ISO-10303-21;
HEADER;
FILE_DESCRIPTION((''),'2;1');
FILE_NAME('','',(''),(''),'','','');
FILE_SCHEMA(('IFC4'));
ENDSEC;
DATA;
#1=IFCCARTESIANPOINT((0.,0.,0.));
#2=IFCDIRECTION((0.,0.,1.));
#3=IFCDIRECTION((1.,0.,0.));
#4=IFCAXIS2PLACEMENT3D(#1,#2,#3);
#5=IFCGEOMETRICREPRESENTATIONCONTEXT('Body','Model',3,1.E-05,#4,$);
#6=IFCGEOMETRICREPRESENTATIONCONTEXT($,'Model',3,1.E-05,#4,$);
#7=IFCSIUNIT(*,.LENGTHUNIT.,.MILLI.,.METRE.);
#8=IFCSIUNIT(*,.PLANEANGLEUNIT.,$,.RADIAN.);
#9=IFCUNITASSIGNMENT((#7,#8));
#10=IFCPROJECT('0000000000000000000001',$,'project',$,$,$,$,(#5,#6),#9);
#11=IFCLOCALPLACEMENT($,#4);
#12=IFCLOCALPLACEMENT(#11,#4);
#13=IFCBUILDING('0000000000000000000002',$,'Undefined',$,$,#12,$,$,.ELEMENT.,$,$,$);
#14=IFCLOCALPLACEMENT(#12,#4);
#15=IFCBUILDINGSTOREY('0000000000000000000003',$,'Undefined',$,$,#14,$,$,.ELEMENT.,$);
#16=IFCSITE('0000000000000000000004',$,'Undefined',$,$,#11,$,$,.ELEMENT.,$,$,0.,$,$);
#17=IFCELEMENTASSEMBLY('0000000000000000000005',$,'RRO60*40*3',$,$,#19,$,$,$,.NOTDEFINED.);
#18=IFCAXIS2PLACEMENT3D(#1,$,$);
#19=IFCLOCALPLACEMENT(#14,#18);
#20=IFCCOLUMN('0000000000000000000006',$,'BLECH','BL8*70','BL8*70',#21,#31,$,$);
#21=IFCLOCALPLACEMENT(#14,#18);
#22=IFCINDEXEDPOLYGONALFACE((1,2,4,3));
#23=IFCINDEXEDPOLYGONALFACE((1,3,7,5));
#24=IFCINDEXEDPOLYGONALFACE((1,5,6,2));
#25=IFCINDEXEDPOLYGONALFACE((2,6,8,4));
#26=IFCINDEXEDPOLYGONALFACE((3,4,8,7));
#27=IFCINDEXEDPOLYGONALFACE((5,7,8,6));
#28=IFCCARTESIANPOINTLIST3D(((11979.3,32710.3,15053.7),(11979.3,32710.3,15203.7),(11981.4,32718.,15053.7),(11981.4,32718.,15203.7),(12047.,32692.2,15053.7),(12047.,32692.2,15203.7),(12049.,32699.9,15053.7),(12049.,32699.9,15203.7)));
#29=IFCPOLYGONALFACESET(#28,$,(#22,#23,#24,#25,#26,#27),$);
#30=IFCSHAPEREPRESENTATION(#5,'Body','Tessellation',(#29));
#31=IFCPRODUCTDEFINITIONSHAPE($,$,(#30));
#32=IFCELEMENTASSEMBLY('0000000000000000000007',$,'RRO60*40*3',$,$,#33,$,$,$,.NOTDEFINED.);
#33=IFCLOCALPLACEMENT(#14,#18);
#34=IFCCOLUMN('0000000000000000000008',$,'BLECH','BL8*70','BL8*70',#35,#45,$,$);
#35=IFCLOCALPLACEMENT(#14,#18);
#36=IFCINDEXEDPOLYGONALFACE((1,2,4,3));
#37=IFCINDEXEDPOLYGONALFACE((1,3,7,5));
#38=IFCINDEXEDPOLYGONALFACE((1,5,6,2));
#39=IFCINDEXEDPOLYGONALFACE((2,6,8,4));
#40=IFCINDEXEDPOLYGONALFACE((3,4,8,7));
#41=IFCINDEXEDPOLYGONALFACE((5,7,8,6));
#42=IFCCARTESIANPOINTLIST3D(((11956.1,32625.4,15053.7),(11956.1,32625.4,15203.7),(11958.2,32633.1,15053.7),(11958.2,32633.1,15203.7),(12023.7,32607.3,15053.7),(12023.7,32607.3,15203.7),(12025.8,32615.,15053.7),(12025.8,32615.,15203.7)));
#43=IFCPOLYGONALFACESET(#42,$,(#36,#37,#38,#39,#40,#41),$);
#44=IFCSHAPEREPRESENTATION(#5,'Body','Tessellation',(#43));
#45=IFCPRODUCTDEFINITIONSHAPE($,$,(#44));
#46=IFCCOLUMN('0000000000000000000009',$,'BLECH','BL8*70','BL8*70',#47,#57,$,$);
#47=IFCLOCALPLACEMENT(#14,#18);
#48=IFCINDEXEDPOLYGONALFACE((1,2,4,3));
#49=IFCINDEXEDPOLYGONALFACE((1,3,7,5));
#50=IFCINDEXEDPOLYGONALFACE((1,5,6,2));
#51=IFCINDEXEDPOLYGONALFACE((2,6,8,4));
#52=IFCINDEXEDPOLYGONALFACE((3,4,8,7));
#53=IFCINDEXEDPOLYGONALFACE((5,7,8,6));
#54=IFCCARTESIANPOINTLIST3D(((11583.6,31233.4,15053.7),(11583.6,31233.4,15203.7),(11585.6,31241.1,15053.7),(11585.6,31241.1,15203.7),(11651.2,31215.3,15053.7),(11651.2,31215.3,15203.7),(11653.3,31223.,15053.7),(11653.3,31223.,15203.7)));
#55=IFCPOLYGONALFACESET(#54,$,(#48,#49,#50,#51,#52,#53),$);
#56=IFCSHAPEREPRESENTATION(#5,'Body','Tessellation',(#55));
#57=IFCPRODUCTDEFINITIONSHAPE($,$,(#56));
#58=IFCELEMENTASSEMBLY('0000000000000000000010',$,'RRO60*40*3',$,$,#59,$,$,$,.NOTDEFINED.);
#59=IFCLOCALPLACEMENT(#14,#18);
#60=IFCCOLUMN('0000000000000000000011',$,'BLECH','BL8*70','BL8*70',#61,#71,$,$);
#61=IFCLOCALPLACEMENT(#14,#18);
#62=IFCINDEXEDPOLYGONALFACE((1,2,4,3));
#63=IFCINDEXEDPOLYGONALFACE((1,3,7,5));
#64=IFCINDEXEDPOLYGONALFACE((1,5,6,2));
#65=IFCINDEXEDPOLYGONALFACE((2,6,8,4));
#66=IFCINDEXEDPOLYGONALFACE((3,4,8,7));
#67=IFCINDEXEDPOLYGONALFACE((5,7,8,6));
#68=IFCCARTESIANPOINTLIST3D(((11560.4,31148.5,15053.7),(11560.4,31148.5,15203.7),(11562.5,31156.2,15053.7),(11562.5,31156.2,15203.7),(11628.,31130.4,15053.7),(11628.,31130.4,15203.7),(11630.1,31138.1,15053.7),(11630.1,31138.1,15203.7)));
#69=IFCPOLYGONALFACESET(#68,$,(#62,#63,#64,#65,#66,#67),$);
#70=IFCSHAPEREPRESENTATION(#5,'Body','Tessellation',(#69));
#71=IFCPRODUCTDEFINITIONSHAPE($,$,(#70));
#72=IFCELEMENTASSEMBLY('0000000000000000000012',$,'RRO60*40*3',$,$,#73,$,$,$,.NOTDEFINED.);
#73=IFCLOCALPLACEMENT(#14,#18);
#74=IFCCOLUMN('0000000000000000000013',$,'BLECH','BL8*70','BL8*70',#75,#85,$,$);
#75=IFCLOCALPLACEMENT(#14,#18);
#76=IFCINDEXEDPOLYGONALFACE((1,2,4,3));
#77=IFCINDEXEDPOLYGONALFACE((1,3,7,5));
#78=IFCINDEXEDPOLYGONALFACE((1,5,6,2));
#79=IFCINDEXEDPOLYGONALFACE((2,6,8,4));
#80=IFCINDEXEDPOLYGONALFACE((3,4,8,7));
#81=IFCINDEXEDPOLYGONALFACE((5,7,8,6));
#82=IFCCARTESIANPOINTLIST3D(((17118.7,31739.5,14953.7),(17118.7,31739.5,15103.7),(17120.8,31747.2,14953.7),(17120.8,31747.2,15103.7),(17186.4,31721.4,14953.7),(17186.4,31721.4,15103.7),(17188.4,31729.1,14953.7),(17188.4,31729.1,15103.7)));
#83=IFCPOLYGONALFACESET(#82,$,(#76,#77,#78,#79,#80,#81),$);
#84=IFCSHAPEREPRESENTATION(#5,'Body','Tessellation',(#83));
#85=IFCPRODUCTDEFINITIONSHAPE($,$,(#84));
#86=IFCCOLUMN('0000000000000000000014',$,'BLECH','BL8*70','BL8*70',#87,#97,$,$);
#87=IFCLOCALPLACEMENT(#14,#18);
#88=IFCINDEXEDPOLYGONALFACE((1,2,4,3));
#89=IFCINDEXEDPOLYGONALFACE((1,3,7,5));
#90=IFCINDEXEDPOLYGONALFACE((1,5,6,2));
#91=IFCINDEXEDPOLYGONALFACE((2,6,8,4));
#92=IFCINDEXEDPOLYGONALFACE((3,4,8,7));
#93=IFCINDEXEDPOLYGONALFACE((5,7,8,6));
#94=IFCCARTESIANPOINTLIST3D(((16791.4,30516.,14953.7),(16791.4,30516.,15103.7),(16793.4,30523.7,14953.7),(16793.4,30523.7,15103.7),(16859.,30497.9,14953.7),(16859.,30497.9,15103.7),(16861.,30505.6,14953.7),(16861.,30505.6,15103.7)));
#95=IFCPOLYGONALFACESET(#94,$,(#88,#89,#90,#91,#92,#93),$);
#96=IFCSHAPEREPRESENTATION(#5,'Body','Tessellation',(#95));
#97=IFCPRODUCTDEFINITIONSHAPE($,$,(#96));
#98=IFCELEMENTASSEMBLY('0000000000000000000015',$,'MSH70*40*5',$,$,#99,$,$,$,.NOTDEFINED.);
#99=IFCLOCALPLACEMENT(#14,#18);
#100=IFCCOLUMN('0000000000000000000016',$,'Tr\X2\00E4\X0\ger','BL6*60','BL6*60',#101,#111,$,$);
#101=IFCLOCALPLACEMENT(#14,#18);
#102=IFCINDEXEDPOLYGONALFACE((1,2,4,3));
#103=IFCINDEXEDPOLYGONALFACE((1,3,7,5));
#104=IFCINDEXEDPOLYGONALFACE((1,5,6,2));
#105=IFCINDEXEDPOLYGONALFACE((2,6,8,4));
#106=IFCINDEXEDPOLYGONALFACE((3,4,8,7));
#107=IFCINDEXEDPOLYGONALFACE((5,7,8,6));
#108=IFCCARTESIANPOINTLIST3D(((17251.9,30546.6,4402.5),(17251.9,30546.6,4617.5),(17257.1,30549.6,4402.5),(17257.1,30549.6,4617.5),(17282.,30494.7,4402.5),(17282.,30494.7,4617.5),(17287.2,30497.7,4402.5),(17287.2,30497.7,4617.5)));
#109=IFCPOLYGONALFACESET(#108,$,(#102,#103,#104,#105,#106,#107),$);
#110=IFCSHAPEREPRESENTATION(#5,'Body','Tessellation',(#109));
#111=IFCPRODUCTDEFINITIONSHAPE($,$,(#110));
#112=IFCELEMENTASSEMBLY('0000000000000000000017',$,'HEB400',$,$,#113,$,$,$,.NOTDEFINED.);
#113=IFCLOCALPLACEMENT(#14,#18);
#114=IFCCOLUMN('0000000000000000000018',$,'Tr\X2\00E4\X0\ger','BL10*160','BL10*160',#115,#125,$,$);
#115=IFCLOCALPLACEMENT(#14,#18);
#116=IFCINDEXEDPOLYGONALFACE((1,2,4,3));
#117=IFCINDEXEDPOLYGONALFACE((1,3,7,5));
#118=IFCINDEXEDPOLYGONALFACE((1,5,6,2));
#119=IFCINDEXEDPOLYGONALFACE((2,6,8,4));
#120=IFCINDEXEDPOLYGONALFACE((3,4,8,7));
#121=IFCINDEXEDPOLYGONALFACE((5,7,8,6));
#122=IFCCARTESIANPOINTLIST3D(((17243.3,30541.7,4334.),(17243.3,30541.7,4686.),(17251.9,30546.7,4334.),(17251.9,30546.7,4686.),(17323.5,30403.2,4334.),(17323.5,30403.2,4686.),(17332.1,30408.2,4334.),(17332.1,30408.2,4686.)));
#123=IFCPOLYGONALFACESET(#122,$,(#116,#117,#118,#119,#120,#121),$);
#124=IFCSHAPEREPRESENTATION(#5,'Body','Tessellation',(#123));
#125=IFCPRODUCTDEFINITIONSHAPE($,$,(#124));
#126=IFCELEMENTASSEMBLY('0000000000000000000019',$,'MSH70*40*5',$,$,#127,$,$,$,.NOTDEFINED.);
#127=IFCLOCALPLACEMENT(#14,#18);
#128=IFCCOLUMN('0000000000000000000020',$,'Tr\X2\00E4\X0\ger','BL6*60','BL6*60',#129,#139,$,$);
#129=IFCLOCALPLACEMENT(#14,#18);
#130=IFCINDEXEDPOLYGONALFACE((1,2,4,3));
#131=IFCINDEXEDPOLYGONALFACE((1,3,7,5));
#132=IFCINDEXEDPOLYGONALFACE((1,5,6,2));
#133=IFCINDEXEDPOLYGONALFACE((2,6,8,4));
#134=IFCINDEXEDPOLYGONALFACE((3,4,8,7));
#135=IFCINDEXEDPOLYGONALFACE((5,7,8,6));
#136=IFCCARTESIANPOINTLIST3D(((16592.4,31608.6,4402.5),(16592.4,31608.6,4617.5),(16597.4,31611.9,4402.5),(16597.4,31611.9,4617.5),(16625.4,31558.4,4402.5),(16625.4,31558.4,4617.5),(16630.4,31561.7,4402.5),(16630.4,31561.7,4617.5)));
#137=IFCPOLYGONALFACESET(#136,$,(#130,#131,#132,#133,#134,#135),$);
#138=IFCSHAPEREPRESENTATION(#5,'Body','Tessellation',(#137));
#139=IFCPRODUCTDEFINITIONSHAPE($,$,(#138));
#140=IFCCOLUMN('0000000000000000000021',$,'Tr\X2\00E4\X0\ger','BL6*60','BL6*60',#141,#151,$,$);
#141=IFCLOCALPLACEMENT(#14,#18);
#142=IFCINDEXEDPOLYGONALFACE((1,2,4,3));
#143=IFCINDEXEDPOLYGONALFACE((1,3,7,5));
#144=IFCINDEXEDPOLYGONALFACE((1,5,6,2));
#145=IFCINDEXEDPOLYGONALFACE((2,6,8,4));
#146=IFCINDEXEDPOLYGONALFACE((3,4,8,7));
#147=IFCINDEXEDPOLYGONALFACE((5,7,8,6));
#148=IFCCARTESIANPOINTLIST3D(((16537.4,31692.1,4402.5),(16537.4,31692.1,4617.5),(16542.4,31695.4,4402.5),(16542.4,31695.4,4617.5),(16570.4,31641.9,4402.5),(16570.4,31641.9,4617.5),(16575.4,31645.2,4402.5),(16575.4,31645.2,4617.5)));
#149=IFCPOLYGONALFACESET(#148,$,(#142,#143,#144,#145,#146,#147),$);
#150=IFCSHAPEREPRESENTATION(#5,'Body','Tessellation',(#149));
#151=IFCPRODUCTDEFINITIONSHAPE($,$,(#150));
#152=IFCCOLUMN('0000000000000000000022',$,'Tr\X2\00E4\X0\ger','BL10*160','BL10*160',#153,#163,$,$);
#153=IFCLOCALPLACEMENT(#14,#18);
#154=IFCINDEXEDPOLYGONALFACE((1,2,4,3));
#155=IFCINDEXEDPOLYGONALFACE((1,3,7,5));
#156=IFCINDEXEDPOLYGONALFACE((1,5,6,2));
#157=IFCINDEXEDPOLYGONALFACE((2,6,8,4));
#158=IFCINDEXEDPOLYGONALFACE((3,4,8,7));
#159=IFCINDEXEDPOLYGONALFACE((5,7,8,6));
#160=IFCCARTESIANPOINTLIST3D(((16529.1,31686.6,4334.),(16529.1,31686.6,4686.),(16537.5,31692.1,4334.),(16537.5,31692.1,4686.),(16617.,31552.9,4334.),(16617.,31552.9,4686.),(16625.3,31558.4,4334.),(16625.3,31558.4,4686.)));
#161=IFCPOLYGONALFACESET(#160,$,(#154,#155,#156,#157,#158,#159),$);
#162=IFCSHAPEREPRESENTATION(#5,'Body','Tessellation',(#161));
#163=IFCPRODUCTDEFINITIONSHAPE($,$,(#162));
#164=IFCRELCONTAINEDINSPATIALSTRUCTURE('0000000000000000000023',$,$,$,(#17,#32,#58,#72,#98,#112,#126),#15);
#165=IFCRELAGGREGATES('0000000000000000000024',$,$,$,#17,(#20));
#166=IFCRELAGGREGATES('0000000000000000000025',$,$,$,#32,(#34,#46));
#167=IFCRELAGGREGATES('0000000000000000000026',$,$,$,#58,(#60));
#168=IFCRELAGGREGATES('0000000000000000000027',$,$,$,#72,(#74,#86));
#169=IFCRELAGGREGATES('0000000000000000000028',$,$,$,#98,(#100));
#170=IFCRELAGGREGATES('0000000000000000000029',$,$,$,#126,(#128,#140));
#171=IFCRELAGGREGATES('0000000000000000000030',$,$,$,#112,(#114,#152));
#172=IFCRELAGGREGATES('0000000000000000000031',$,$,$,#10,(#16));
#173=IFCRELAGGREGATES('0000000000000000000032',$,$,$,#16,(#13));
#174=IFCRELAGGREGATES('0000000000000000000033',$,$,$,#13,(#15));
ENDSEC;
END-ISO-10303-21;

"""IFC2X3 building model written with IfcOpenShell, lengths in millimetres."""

from ifc_helpers import new_model, si_unit, frame, origin_with_axes, origin_2d_with_axis, place, context, project, spatial, rectangle, extrude, element, aggregate, save


model = new_model("IFC2X3")

# Units and contexts
model_context_1 = context("Model", 3, precision=1e-05, world=origin_with_axes(), identifier="Body")
model_context_2 = context("Model", 3, precision=1e-05, world=origin_with_axes())
ifc_project = project(units=[si_unit("LENGTHUNIT", "METRE", prefix="MILLI"), si_unit("PLANEANGLEUNIT", "RADIAN")], contexts=[model_context_1, model_context_2])

# Site, building, storey
site_placement = place(None, origin_with_axes())
site = spatial("IfcSite", under=ifc_project, at=site_placement, Name="Undefined", CompositionType="ELEMENT", RefElevation=0.0)
building_placement = place(site_placement, origin_with_axes())
building = spatial("IfcBuilding", under=site, at=building_placement, Name="Undefined", CompositionType="ELEMENT")
storey_placement = place(building_placement, origin_with_axes())
storey = spatial("IfcBuildingStorey", under=building, at=storey_placement, Name="Undefined", CompositionType="ELEMENT")

# Element assembly, column
assembly_1 = element("IfcElementAssembly", 1, inside=storey, Name="RRO60*40*3", PredefinedType="NOTDEFINED")
column_1_placement = place(storey_placement, frame((12014.2, 32705.1, 15053.7), z_axis=(0.0, 0.0, 1.0), x_axis=(1.0, 0.0, 0.0)))
column_1 = element("IfcColumn", 2, at=column_1_placement, Name="BLECH", Description="BL8*70", ObjectType="BL8*70", context=model_context_1, shape_type="SweptSolid", body=[
    extrude(rectangle(XDim=8.0, YDim=70.0, at=origin_2d_with_axis()), frame((0.0, 0.0, 150.0), z_axis=(0.0, 0.0, -1.0), x_axis=(0.258425, 0.966031, -0.000005)), (0.0, 0.0, 1.0), 150.0),
])
aggregate(assembly_1, [column_1])

# Element assembly, columns
assembly_2 = element("IfcElementAssembly", 3, inside=storey, Name="RRO60*40*3", PredefinedType="NOTDEFINED")
column_2_placement = place(storey_placement, frame((11991.0, 32620.2, 15053.7), z_axis=(0.0, 0.0, 1.0), x_axis=(1.0, 0.0, 0.0)))
column_2 = element("IfcColumn", 4, at=column_2_placement, Name="BLECH", Description="BL8*70", ObjectType="BL8*70", context=model_context_1, shape_type="SweptSolid", body=[
    extrude(rectangle(XDim=8.0, YDim=70.0, at=origin_2d_with_axis()), frame((0.0, 0.0, 150.0), z_axis=(0.0, 0.0, -1.0), x_axis=(-0.258545, -0.965999, 0.000005)), (0.0, 0.0, 1.0), 150.0),
])
column_3_placement = place(storey_placement, frame((11618.4, 31228.2, 15053.7), z_axis=(0.0, 0.0, 1.0), x_axis=(1.0, 0.0, 0.0)))
column_3 = element("IfcColumn", 5, at=column_3_placement, Name="BLECH", Description="BL8*70", ObjectType="BL8*70", context=model_context_1, shape_type="SweptSolid", body=[
    extrude(rectangle(XDim=8.0, YDim=70.0, at=origin_2d_with_axis()), frame((0.0, 0.0, 150.0), z_axis=(0.0, 0.0, -1.0), x_axis=(0.258545, 0.965999, -0.000005)), (0.0, 0.0, 1.0), 150.0),
])
aggregate(assembly_2, [column_2, column_3])

# Element assembly, column
assembly_3 = element("IfcElementAssembly", 6, inside=storey, Name="RRO60*40*3", PredefinedType="NOTDEFINED")
column_4_placement = place(storey_placement, frame((11595.2, 31143.3, 15053.7), z_axis=(0.0, 0.0, 1.0), x_axis=(1.0, 0.0, 0.0)))
column_4 = element("IfcColumn", 7, at=column_4_placement, Name="BLECH", Description="BL8*70", ObjectType="BL8*70", context=model_context_1, shape_type="SweptSolid", body=[
    extrude(rectangle(XDim=8.0, YDim=70.0, at=origin_2d_with_axis()), frame((0.0, 0.0, 150.0), z_axis=(0.0, 0.0, -1.0), x_axis=(-0.258572, -0.965992, 0.000005)), (0.0, 0.0, 1.0), 150.0),
])
aggregate(assembly_3, [column_4])

# Element assembly, columns
assembly_4 = element("IfcElementAssembly", 8, inside=storey, Name="RRO60*40*3", PredefinedType="NOTDEFINED")
column_5_placement = place(storey_placement, frame((17153.6, 31734.3, 14953.7), z_axis=(0.0, 0.0, 1.0), x_axis=(1.0, 0.0, 0.0)))
column_5 = element("IfcColumn", 9, at=column_5_placement, Name="BLECH", Description="BL8*70", ObjectType="BL8*70", context=model_context_1, shape_type="SweptSolid", body=[
    extrude(rectangle(XDim=8.0, YDim=70.0, at=origin_2d_with_axis()), frame((0.0, 0.0, 150.0), z_axis=(0.0, 0.0, -1.0), x_axis=(-0.258482, -0.966016, 0.000005)), (0.0, 0.0, 1.0), 150.0),
])
column_6_placement = place(storey_placement, frame((16826.2, 30510.8, 14953.7), z_axis=(0.0, 0.0, 1.0), x_axis=(1.0, 0.0, 0.0)))
column_6 = element("IfcColumn", 10, at=column_6_placement, Name="BLECH", Description="BL8*70", ObjectType="BL8*70", context=model_context_1, shape_type="SweptSolid", body=[
    extrude(rectangle(XDim=8.0, YDim=70.0, at=origin_2d_with_axis()), frame((0.0, 0.0, 150.0), z_axis=(0.0, 0.0, -1.0), x_axis=(0.258482, 0.966016, -0.000005)), (0.0, 0.0, 1.0), 150.0),
])
aggregate(assembly_4, [column_5, column_6])

# Element assemblies, columns
assembly_5 = element("IfcElementAssembly", 11, inside=storey, Name="MSH70*40*5", PredefinedType="NOTDEFINED")
column_7_placement = place(storey_placement, frame((17269.5, 30522.2, 4402.5), z_axis=(0.0, 0.0, 1.0), x_axis=(1.0, 0.0, 0.0)))
column_7 = element("IfcColumn", 12, at=column_7_placement, Name="Träger", Description="BL6*60", ObjectType="BL6*60", context=model_context_1, shape_type="SweptSolid", body=[
    extrude(rectangle(XDim=6.0, YDim=60.0, at=origin_2d_with_axis()), frame((0.0, 0.0, 215.0), z_axis=(0.0, 0.0, -1.0), x_axis=(0.865327, 0.501209, 0.0)), (0.0, 0.0, 1.0), 215.0),
])
aggregate(assembly_5, [column_7])
assembly_6 = element("IfcElementAssembly", 13, inside=storey, Name="HEB400", PredefinedType="NOTDEFINED")
column_8_placement = place(storey_placement, frame((17287.7, 30474.9, 4334.0), z_axis=(0.0, 0.0, 1.0), x_axis=(1.0, 0.0, 0.0)))
column_8 = element("IfcColumn", 14, at=column_8_placement, Name="Träger", Description="BL10*160", ObjectType="BL10*160", context=model_context_1, shape_type="SweptSolid", body=[
    extrude(rectangle(XDim=10.0, YDim=160.0, at=origin_2d_with_axis()), frame((0.0, 0.0, 352.0), z_axis=(0.0, 0.0, -1.0), x_axis=(0.865327, 0.501209, 0.0)), (0.0, 0.0, 1.0), 352.0),
])

# Element assembly, columns
assembly_7 = element("IfcElementAssembly", 15, inside=storey, Name="MSH70*40*5", PredefinedType="NOTDEFINED")
column_9_placement = place(storey_placement, frame((16611.4, 31585.1, 4402.5), z_axis=(0.0, 0.0, 1.0), x_axis=(1.0, 0.0, 0.0)))
column_9 = element("IfcColumn", 16, at=column_9_placement, Name="Träger", Description="BL6*60", ObjectType="BL6*60", context=model_context_1, shape_type="SweptSolid", body=[
    extrude(rectangle(XDim=6.0, YDim=60.0, at=origin_2d_with_axis()), frame((0.0, 0.0, 215.0), z_axis=(0.0, 0.0, -1.0), x_axis=(0.835807, 0.549023, 0.0)), (0.0, 0.0, 1.0), 215.0),
])
column_10_placement = place(storey_placement, frame((16556.4, 31668.6, 4402.5), z_axis=(0.0, 0.0, 1.0), x_axis=(1.0, 0.0, 0.0)))
column_10 = element("IfcColumn", 17, at=column_10_placement, Name="Träger", Description="BL6*60", ObjectType="BL6*60", context=model_context_1, shape_type="SweptSolid", body=[
    extrude(rectangle(XDim=6.0, YDim=60.0, at=origin_2d_with_axis()), frame((0.0, 0.0, 215.0), z_axis=(0.0, 0.0, -1.0), x_axis=(0.835807, 0.549023, 0.0)), (0.0, 0.0, 1.0), 215.0),
])

# Column
column_11_placement = place(storey_placement, frame((16577.2, 31622.5, 4334.0), z_axis=(0.0, 0.0, 1.0), x_axis=(1.0, 0.0, 0.0)))
column_11 = element("IfcColumn", 18, at=column_11_placement, Name="Träger", Description="BL10*160", ObjectType="BL10*160", context=model_context_1, shape_type="SweptSolid", body=[
    extrude(rectangle(XDim=10.0, YDim=160.0, at=origin_2d_with_axis()), frame((0.0, 0.0, 352.0), z_axis=(0.0, 0.0, -1.0), x_axis=(0.835807, 0.549023, 0.0)), (0.0, 0.0, 1.0), 352.0),
])
aggregate(assembly_7, [column_9, column_10])

aggregate(assembly_6, [column_8, column_11])

save(model, "model.ifc")
